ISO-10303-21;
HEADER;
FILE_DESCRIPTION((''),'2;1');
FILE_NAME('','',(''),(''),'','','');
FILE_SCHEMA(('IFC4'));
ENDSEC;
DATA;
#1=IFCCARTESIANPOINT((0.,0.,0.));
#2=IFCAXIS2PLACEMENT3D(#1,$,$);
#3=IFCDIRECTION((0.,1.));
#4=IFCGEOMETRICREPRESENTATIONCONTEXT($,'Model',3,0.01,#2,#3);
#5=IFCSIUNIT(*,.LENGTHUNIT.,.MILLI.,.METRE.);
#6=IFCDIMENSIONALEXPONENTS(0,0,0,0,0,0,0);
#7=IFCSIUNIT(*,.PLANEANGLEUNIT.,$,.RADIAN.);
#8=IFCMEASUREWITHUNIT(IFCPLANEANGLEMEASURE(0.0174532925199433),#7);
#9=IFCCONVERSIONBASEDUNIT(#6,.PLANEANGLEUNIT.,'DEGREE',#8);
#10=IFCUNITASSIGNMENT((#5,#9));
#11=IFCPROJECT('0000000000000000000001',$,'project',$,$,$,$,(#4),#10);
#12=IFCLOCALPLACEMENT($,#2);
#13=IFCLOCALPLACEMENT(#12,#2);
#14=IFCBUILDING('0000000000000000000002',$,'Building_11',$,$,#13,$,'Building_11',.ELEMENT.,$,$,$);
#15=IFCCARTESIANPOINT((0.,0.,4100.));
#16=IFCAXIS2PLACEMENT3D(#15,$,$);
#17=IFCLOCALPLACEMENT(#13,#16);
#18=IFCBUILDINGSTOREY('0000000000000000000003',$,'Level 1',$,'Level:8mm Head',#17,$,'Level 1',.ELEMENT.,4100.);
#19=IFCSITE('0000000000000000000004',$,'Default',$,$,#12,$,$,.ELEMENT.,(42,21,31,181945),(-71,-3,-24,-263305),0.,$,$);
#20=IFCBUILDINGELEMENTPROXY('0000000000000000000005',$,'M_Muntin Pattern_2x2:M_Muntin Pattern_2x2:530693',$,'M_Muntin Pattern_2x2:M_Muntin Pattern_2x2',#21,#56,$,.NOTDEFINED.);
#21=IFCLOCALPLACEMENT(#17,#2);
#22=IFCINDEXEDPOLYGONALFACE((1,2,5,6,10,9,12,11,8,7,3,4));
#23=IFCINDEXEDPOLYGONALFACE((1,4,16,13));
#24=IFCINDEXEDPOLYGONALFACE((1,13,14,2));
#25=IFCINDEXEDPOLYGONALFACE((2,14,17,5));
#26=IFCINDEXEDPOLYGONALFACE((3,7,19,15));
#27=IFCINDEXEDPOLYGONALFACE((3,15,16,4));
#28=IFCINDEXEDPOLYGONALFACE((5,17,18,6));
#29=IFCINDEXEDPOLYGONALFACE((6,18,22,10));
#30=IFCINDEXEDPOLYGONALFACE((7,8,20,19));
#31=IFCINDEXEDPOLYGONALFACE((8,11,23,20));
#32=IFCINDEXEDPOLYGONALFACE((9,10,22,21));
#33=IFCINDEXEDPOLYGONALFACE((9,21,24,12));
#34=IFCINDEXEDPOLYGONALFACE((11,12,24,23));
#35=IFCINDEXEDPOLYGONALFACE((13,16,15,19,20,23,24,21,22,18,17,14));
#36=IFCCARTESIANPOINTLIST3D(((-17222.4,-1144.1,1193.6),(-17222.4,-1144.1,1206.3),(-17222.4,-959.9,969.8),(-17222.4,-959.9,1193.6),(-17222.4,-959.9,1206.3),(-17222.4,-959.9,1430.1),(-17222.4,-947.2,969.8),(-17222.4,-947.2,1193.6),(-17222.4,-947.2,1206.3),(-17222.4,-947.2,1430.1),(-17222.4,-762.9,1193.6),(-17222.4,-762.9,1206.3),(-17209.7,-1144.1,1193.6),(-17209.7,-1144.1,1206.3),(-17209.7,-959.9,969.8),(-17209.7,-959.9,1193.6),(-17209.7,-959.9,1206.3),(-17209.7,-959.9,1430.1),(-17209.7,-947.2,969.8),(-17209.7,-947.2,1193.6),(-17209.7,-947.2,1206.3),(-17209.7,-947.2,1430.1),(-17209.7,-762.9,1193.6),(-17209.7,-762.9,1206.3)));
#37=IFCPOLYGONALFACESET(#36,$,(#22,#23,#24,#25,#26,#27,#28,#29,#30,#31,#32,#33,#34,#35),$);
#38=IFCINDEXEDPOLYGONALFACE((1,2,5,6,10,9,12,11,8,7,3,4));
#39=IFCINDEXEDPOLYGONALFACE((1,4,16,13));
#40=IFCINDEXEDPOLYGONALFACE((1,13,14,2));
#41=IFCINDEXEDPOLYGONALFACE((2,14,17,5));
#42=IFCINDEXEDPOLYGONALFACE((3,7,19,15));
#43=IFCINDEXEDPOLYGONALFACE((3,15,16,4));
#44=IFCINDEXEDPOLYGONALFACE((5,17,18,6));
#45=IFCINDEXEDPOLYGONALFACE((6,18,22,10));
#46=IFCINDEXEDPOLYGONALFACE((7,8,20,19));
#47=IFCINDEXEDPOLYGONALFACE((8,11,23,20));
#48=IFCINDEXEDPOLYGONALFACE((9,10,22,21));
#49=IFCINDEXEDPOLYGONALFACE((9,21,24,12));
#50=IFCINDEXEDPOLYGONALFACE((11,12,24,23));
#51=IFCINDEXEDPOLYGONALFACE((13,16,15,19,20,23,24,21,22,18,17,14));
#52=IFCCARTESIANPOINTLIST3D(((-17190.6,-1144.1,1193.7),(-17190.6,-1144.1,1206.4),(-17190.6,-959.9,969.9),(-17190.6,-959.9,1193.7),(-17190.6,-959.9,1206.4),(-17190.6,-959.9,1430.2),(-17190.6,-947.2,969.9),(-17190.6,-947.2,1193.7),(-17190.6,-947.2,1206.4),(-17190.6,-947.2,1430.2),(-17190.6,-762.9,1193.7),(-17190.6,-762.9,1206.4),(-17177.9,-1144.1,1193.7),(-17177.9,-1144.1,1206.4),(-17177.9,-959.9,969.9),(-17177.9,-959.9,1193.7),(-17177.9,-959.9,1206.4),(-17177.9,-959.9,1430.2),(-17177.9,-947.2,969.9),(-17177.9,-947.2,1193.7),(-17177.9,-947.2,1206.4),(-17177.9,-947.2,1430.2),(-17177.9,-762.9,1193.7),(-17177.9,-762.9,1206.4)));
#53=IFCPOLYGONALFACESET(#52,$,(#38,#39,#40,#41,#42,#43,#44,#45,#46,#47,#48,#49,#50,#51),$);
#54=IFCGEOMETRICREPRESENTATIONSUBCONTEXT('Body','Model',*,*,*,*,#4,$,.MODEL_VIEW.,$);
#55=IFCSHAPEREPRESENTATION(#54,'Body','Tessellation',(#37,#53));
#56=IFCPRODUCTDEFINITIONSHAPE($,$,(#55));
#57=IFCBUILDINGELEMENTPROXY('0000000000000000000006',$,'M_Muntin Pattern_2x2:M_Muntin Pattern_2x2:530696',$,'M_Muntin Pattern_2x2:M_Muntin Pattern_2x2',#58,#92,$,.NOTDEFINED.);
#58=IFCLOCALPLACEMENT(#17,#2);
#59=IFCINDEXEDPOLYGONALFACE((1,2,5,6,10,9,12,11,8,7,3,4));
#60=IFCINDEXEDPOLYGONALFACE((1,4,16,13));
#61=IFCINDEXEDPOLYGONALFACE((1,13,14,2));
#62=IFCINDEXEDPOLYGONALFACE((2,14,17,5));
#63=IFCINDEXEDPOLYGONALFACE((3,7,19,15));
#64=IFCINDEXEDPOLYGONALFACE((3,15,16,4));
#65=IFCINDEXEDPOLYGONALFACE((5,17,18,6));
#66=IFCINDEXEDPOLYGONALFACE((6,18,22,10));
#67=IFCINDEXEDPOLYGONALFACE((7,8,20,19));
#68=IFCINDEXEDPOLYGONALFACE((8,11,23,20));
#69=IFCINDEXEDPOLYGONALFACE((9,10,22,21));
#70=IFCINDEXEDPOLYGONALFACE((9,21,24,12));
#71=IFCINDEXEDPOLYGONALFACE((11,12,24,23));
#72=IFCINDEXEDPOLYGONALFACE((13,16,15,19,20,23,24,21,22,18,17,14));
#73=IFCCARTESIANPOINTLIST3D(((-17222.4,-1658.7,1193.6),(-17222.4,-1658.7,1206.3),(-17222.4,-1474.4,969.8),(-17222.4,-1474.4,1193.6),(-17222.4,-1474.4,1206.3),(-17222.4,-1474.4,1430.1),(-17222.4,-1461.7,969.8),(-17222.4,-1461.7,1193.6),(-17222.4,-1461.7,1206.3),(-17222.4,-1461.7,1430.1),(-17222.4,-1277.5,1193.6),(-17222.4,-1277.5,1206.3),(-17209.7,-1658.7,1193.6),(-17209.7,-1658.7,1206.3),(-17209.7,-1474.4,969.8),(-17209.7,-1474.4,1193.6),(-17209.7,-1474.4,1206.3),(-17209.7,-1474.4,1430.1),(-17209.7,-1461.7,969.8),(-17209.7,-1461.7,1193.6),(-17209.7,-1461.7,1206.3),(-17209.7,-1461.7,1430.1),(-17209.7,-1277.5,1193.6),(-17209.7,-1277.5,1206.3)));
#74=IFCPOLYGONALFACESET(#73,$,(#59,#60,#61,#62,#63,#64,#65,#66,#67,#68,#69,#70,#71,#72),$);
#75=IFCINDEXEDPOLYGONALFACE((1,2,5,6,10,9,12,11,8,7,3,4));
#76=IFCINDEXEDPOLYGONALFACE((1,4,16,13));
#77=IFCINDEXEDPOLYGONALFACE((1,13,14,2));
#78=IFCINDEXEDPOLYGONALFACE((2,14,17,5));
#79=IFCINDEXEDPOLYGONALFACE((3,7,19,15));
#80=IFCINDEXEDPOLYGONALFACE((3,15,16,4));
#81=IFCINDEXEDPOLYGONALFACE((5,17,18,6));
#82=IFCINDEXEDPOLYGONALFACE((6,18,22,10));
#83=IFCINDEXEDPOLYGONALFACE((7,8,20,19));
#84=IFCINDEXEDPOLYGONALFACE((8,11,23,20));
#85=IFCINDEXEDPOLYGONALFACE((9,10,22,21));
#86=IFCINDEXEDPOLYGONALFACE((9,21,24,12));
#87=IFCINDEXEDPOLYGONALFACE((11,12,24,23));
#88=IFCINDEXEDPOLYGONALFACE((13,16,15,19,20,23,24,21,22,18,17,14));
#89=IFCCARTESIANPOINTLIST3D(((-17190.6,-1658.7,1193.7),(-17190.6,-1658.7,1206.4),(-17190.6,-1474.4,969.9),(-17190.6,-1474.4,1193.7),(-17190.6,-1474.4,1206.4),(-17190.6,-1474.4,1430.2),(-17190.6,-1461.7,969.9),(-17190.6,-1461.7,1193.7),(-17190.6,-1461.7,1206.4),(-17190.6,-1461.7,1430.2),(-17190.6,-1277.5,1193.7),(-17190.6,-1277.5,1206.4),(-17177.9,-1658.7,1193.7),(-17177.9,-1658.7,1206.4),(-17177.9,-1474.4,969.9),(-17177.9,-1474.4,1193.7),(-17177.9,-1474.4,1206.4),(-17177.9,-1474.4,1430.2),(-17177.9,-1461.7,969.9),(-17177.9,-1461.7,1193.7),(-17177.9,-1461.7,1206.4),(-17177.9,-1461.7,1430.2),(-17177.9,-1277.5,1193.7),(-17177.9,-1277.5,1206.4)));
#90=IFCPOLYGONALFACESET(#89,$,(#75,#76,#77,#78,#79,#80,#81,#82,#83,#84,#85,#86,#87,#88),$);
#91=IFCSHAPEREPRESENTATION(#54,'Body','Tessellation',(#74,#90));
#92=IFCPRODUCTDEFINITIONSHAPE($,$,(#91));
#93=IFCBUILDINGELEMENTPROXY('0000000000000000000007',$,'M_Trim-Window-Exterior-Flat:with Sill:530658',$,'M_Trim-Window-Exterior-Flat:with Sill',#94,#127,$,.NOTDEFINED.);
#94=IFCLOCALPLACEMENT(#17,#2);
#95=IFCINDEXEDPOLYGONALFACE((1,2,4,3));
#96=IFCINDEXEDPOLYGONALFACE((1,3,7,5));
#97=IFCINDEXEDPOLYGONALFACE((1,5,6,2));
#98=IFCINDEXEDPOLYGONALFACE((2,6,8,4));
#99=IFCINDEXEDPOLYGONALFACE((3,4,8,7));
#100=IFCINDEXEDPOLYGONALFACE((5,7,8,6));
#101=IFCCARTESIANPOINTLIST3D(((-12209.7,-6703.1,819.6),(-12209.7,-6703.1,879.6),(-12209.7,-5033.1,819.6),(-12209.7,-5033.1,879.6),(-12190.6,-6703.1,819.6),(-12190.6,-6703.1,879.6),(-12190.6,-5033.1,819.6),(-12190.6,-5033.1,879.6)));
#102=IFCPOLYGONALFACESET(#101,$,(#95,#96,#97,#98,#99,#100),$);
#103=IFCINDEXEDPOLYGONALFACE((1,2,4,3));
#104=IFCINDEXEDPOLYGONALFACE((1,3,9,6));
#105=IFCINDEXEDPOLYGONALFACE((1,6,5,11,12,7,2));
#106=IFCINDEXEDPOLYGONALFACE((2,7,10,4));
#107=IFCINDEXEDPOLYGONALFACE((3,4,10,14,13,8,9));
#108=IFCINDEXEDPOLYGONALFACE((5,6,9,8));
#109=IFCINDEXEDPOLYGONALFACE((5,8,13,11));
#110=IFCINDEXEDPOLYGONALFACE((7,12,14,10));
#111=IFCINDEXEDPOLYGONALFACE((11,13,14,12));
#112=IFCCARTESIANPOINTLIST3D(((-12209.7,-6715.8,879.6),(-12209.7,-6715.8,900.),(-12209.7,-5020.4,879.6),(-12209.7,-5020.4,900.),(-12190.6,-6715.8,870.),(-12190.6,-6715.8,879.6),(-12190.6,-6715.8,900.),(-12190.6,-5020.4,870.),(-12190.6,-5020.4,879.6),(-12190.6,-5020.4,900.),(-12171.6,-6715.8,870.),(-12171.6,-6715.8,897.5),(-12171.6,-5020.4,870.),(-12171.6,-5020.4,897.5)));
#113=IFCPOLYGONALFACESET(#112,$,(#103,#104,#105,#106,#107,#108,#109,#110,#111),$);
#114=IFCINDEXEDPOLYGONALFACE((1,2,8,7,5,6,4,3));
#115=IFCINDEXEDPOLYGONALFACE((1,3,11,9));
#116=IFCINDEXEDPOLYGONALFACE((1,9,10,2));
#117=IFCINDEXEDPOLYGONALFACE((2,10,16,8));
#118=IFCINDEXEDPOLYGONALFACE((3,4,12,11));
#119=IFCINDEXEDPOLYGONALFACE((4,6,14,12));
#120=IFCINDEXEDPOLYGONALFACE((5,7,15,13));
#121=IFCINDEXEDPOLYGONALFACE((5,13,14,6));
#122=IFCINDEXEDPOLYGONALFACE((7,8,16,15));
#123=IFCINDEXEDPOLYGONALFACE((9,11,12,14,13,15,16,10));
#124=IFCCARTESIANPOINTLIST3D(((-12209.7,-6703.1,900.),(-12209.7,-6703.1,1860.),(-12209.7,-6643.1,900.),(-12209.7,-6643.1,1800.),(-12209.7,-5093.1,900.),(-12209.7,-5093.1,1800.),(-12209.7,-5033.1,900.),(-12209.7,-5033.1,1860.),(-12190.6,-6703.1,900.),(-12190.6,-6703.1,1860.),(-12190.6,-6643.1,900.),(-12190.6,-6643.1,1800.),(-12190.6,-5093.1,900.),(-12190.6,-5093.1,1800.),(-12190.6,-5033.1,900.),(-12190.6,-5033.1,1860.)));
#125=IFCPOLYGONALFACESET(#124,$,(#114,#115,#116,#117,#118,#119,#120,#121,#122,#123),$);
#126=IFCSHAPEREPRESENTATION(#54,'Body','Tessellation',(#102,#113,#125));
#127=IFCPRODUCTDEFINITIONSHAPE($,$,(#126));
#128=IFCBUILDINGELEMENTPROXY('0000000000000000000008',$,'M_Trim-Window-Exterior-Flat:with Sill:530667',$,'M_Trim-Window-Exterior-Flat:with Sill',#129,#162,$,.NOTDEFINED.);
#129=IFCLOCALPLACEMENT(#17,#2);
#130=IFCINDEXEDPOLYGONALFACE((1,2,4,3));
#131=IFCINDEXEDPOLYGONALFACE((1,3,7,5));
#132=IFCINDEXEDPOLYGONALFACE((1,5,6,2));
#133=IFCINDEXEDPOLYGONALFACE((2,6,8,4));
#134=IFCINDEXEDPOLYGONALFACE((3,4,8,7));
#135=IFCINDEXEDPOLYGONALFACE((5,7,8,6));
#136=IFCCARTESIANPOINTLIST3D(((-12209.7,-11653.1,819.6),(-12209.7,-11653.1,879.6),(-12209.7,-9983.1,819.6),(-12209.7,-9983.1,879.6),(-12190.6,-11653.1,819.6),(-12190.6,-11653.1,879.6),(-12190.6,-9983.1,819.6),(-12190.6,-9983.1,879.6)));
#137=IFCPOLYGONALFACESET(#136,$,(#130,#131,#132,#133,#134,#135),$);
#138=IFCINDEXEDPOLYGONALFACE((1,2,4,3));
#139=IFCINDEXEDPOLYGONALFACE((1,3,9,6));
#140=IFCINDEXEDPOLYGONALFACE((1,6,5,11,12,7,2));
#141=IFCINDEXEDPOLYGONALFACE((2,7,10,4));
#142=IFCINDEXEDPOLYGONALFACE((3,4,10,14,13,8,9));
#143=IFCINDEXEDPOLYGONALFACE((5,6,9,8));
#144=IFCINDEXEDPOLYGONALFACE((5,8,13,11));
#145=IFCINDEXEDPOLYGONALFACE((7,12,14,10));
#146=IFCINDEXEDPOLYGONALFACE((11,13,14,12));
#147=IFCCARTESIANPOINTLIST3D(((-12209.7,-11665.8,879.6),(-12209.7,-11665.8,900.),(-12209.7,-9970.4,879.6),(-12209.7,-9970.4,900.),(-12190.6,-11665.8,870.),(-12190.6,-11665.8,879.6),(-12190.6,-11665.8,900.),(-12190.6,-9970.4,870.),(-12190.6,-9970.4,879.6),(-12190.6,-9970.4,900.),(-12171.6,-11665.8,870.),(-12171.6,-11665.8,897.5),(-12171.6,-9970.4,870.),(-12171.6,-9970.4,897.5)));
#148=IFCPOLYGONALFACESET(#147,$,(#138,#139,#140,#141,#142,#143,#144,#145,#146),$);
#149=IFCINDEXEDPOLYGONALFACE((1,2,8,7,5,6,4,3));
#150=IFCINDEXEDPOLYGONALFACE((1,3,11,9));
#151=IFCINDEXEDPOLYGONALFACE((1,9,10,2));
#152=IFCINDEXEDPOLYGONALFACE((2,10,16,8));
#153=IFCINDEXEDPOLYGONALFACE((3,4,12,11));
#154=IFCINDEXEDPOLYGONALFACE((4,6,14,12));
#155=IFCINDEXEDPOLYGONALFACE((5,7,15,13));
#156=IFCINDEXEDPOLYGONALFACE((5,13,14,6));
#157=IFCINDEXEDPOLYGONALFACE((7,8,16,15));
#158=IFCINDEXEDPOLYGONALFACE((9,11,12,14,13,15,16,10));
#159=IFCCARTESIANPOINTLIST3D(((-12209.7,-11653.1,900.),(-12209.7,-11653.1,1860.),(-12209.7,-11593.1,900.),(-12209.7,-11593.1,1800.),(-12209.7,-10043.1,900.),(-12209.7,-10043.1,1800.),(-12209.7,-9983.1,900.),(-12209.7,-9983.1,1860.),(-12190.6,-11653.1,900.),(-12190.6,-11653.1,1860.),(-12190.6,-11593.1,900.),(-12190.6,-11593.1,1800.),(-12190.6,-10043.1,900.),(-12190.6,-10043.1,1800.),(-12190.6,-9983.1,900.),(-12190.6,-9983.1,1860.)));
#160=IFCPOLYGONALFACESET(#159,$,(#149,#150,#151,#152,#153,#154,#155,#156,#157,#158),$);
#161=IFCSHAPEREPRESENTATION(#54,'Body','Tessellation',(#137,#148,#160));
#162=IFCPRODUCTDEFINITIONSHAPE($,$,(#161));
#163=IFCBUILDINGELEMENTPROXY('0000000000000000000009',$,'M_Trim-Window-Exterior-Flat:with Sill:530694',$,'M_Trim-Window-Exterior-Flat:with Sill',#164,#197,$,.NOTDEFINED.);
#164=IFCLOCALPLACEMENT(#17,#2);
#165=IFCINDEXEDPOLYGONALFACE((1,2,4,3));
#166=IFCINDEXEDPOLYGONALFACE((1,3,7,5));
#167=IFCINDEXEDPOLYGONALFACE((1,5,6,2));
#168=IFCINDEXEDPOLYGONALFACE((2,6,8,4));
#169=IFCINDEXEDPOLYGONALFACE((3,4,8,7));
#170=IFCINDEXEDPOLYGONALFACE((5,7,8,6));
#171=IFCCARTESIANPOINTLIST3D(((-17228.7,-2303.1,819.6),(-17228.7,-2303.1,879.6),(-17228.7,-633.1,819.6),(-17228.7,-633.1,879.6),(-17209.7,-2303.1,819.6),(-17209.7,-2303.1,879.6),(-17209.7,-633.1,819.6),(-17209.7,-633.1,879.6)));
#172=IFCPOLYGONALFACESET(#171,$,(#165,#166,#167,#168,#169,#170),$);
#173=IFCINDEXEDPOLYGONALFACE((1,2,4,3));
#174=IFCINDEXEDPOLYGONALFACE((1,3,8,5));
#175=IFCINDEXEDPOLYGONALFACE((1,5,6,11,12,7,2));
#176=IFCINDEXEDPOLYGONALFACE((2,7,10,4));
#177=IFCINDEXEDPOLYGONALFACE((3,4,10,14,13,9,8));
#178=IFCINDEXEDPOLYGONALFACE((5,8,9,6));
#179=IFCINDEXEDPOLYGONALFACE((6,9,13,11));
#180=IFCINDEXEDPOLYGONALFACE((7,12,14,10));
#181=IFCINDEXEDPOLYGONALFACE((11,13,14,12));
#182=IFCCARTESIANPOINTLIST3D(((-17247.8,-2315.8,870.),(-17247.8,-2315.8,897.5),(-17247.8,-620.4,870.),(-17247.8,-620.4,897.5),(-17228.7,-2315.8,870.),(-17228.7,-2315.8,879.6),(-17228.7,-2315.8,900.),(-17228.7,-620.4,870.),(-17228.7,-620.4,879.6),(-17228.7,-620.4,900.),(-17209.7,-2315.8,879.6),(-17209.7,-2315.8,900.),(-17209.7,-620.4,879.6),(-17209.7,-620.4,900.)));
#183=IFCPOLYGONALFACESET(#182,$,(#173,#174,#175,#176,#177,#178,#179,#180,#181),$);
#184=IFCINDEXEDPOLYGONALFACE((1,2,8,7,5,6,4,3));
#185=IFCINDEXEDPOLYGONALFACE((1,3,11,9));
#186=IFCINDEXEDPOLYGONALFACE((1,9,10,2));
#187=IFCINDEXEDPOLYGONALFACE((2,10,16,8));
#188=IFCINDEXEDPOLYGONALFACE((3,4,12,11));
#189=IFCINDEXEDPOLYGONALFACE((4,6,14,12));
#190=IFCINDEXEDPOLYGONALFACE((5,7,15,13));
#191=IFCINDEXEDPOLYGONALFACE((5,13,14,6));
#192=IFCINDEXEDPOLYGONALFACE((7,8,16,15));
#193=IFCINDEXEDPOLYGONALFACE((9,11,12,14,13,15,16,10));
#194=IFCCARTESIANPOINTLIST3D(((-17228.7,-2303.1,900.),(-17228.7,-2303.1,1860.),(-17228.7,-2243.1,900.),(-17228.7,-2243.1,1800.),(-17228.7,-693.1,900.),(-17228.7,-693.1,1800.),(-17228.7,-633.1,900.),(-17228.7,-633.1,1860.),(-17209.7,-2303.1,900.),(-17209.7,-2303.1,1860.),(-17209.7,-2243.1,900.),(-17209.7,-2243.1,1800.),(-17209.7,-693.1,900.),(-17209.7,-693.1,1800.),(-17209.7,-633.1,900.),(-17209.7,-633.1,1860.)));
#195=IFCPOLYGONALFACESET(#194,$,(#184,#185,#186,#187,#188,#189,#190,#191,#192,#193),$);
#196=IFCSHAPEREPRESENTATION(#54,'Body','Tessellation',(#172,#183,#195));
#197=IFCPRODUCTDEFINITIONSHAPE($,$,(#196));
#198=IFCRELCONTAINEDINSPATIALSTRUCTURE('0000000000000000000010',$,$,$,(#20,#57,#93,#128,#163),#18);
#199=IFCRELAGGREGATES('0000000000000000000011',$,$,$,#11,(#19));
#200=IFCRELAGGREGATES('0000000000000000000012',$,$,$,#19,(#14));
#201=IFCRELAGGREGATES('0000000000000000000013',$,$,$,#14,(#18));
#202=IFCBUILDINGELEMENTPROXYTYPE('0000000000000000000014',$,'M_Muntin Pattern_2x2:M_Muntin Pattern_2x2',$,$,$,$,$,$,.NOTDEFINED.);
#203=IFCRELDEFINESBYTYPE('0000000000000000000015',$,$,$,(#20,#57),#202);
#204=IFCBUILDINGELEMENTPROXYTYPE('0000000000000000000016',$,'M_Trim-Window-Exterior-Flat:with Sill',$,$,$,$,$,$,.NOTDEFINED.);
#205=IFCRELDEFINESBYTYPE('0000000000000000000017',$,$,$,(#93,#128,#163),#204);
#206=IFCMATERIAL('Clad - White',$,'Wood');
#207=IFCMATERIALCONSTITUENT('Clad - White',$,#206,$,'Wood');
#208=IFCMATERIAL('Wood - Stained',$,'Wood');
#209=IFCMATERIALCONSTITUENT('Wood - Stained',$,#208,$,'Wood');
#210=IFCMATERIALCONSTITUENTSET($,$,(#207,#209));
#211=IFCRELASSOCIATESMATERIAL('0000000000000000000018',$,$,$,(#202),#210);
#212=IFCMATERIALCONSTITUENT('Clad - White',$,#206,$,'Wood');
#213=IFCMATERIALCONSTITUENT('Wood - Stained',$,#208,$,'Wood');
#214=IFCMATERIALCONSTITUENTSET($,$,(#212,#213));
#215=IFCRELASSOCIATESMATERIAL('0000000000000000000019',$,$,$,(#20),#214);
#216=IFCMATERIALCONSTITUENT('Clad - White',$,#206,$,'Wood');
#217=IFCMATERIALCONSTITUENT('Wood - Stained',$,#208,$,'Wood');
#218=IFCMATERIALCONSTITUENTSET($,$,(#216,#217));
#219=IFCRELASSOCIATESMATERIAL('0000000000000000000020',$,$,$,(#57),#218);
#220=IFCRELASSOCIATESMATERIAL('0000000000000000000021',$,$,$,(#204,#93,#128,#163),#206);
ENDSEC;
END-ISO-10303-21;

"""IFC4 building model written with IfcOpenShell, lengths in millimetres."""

from ifc_helpers import new_model, entity, si_unit, converted_unit, direction, frame, origin, place, context, subcontext, project, spatial, indexed_curve, outline, extrude, source, transform, mapped, material, constituent, constituent_set, type_object, type_shapes, element, save


model = new_model("IFC4")

# Units and contexts
model_context = context("Model", 3, precision=0.01, world=origin(), true_north=direction((0.0, 1.0)))
body_context = subcontext(model_context, "Body", "Model", "MODEL_VIEW")
ifc_project = project(units=[si_unit("LENGTHUNIT", "METRE", prefix="MILLI"), converted_unit("PLANEANGLEUNIT", "DEGREE", entity("IfcPlaneAngleMeasure", 0.0174532925199433), si_unit("PLANEANGLEUNIT", "RADIAN"), dimensions=[0, 0, 0, 0, 0, 0, 0])], contexts=[model_context])

# Site, building, storey
site_placement = place(None, origin())
site = spatial("IfcSite", under=ifc_project, at=site_placement, Name="Default", CompositionType="ELEMENT", RefLatitude=(42, 21, 31, 181945), RefLongitude=(-71, -3, -24, -263305), RefElevation=0.0)
building_placement = place(site_placement, origin())
building = spatial("IfcBuilding", under=site, at=building_placement, Name="Building_11", LongName="Building_11", CompositionType="ELEMENT")
storey_placement = place(building_placement, frame((0.0, 0.0, 4100.0)))
storey = spatial("IfcBuildingStorey", under=building, at=storey_placement, Name="Level 1", ObjectType="Level:8mm Head", LongName="Level 1", CompositionType="ELEMENT", Elevation=4100.0)

# Building element proxies
ifc_material_1 = material(Name="Clad - White", Category="Wood")
ifc_material_2 = material(Name="Wood - Stained", Category="Wood")
ifc_constituent_1 = constituent(ifc_material_1, Name="Clad - White", Category="Wood")
ifc_constituent_2 = constituent(ifc_material_2, Name="Wood - Stained", Category="Wood")
ifc_constituent_set_1 = constituent_set(constituents=[ifc_constituent_1, ifc_constituent_2])
building_element_proxy_type_1 = type_object("IfcBuildingElementProxyType", Name="M_Muntin Pattern_2x2:M_Muntin Pattern_2x2", PredefinedType="NOTDEFINED", material=ifc_constituent_set_1)
shared_shape_1 = source(origin(), body_context, "Body", "SweptSolid", [
    extrude(outline(indexed_curve([(6.4, -6.4), (230.1, -6.4), (230.1, 6.3), (6.4, 6.3), (6.4, 190.6), (-6.3, 190.6), (-6.3, 6.3), (-230.2, 6.3), (-230.2, -6.4), (-6.3, -6.4), (-6.3, -190.6), (6.4, -190.6), (6.4, -6.4)], self_intersect=False)), frame((0.0, -22.2, 230.1), z_axis=(0.0, 1.0, 0.0), x_axis=(0.0, 0.0, 1.0)), (0.0, 0.0, 1.0), 12.7),
    extrude(outline(indexed_curve([(6.4, -6.4), (230.2, -6.4), (230.2, 6.3), (6.4, 6.3), (6.4, 190.6), (-6.3, 190.6), (-6.3, 6.3), (-230.2, 6.3), (-230.2, -6.4), (-6.3, -6.4), (-6.3, -190.6), (6.4, -190.6), (6.4, -6.4)], self_intersect=False)), frame((0.0, 9.5, 230.2), z_axis=(0.0, 1.0, 0.0), x_axis=(0.0, 0.0, 1.0)), (0.0, 0.0, 1.0), 12.7),
])
type_shapes(building_element_proxy_type_1, [shared_shape_1])
ifc_constituent_3 = constituent(ifc_material_1, Name="Clad - White", Category="Wood")
ifc_constituent_4 = constituent(ifc_material_2, Name="Wood - Stained", Category="Wood")
ifc_constituent_set_2 = constituent_set(constituents=[ifc_constituent_3, ifc_constituent_4])
proxy_1_placement = place(storey_placement, frame((-17200.2, -953.5, 969.9), z_axis=(0.0, 0.0, 1.0), x_axis=(0.0, -1.0, 0.0)))
element("IfcBuildingElementProxy", 1, at=proxy_1_placement, inside=storey, type_object=building_element_proxy_type_1, material=ifc_constituent_set_2, Name="M_Muntin Pattern_2x2:M_Muntin Pattern_2x2:530693", ObjectType="M_Muntin Pattern_2x2:M_Muntin Pattern_2x2", PredefinedType="NOTDEFINED", context=body_context, shape_type="MappedRepresentation", body=[
    mapped(shared_shape_1, transform((0.0, 0.0, 0.0), scale=1.0)),
])
ifc_constituent_5 = constituent(ifc_material_1, Name="Clad - White", Category="Wood")
ifc_constituent_6 = constituent(ifc_material_2, Name="Wood - Stained", Category="Wood")
ifc_constituent_set_3 = constituent_set(constituents=[ifc_constituent_5, ifc_constituent_6])
proxy_2_placement = place(storey_placement, frame((-17200.2, -1468.1, 969.9), z_axis=(0.0, 0.0, 1.0), x_axis=(0.0, -1.0, 0.0)))
element("IfcBuildingElementProxy", 2, at=proxy_2_placement, inside=storey, type_object=building_element_proxy_type_1, material=ifc_constituent_set_3, Name="M_Muntin Pattern_2x2:M_Muntin Pattern_2x2:530696", ObjectType="M_Muntin Pattern_2x2:M_Muntin Pattern_2x2", PredefinedType="NOTDEFINED", context=body_context, shape_type="MappedRepresentation", body=[
    mapped(shared_shape_1, transform((0.0, 0.0, 0.0), scale=1.0)),
])
building_element_proxy_type_2 = type_object("IfcBuildingElementProxyType", Name="M_Trim-Window-Exterior-Flat:with Sill", PredefinedType="NOTDEFINED", material=ifc_material_1)
shared_shape_2 = source(origin(), body_context, "Body", "SweptSolid", [
    extrude(outline(indexed_curve([(-835.0, -30.0), (835.0, -30.0), (835.0, 30.0), (-835.0, 30.0), (-835.0, -30.0)], self_intersect=False)), frame((0.0, -950.4, 0.0), z_axis=(0.0, 0.0, 1.0), x_axis=(-1.0, 0.0, 0.0)), (0.0, 0.0, 1.0), 19.1),
    extrude(outline(indexed_curve([(-19.0, -15.2), (0.0, -15.2), (0.0, -5.7), (19.0, -5.7), (19.0, 14.8), (0.0, 14.8), (-19.0, 12.3), (-19.0, -15.2)], self_intersect=False)), frame((-847.7, -914.8, 19.0), z_axis=(1.0, 0.0, 0.0), x_axis=(0.0, 0.0, -1.0)), (0.0, 0.0, 1.0), 1695.4),
    extrude(outline(indexed_curve([(-495.0, -835.0), (465.0, -835.0), (465.0, -775.0), (-435.0, -775.0), (-435.0, 775.0), (465.0, 775.0), (465.0, 835.0), (-495.0, 835.0), (-495.0, -835.0)], self_intersect=False)), frame((0.0, -435.0, 0.0), z_axis=(0.0, 0.0, 1.0), x_axis=(0.0, -1.0, 0.0)), (0.0, 0.0, 1.0), 19.1),
])
type_shapes(building_element_proxy_type_2, [shared_shape_2])
for number, where, z_axis, x_axis, name in (
    (3, (-12209.7, -5868.1, 1800.0), (1.0, 0.0, 0.0), (0.0, 1.0, 0.0), "M_Trim-Window-Exterior-Flat:with Sill:530658"),
    (4, (-12209.7, -10818.1, 1800.0), (1.0, 0.0, 0.0), (0.0, 1.0, 0.0), "M_Trim-Window-Exterior-Flat:with Sill:530667"),
    (5, (-17209.7, -1468.1, 1800.0), (-1.0, 0.0, 0.0), (0.0, -1.0, 0.0), "M_Trim-Window-Exterior-Flat:with Sill:530694"),
):
    element("IfcBuildingElementProxy", number, at=place(storey_placement, frame(where, z_axis=z_axis, x_axis=x_axis)), inside=storey, type_object=building_element_proxy_type_2, material=ifc_material_1, Name=name, ObjectType="M_Trim-Window-Exterior-Flat:with Sill", PredefinedType="NOTDEFINED", context=body_context, shape_type="MappedRepresentation", body=[
        mapped(shared_shape_2, transform((0.0, 0.0, 0.0), scale=1.0)),
    ])

save(model, "model.ifc")
